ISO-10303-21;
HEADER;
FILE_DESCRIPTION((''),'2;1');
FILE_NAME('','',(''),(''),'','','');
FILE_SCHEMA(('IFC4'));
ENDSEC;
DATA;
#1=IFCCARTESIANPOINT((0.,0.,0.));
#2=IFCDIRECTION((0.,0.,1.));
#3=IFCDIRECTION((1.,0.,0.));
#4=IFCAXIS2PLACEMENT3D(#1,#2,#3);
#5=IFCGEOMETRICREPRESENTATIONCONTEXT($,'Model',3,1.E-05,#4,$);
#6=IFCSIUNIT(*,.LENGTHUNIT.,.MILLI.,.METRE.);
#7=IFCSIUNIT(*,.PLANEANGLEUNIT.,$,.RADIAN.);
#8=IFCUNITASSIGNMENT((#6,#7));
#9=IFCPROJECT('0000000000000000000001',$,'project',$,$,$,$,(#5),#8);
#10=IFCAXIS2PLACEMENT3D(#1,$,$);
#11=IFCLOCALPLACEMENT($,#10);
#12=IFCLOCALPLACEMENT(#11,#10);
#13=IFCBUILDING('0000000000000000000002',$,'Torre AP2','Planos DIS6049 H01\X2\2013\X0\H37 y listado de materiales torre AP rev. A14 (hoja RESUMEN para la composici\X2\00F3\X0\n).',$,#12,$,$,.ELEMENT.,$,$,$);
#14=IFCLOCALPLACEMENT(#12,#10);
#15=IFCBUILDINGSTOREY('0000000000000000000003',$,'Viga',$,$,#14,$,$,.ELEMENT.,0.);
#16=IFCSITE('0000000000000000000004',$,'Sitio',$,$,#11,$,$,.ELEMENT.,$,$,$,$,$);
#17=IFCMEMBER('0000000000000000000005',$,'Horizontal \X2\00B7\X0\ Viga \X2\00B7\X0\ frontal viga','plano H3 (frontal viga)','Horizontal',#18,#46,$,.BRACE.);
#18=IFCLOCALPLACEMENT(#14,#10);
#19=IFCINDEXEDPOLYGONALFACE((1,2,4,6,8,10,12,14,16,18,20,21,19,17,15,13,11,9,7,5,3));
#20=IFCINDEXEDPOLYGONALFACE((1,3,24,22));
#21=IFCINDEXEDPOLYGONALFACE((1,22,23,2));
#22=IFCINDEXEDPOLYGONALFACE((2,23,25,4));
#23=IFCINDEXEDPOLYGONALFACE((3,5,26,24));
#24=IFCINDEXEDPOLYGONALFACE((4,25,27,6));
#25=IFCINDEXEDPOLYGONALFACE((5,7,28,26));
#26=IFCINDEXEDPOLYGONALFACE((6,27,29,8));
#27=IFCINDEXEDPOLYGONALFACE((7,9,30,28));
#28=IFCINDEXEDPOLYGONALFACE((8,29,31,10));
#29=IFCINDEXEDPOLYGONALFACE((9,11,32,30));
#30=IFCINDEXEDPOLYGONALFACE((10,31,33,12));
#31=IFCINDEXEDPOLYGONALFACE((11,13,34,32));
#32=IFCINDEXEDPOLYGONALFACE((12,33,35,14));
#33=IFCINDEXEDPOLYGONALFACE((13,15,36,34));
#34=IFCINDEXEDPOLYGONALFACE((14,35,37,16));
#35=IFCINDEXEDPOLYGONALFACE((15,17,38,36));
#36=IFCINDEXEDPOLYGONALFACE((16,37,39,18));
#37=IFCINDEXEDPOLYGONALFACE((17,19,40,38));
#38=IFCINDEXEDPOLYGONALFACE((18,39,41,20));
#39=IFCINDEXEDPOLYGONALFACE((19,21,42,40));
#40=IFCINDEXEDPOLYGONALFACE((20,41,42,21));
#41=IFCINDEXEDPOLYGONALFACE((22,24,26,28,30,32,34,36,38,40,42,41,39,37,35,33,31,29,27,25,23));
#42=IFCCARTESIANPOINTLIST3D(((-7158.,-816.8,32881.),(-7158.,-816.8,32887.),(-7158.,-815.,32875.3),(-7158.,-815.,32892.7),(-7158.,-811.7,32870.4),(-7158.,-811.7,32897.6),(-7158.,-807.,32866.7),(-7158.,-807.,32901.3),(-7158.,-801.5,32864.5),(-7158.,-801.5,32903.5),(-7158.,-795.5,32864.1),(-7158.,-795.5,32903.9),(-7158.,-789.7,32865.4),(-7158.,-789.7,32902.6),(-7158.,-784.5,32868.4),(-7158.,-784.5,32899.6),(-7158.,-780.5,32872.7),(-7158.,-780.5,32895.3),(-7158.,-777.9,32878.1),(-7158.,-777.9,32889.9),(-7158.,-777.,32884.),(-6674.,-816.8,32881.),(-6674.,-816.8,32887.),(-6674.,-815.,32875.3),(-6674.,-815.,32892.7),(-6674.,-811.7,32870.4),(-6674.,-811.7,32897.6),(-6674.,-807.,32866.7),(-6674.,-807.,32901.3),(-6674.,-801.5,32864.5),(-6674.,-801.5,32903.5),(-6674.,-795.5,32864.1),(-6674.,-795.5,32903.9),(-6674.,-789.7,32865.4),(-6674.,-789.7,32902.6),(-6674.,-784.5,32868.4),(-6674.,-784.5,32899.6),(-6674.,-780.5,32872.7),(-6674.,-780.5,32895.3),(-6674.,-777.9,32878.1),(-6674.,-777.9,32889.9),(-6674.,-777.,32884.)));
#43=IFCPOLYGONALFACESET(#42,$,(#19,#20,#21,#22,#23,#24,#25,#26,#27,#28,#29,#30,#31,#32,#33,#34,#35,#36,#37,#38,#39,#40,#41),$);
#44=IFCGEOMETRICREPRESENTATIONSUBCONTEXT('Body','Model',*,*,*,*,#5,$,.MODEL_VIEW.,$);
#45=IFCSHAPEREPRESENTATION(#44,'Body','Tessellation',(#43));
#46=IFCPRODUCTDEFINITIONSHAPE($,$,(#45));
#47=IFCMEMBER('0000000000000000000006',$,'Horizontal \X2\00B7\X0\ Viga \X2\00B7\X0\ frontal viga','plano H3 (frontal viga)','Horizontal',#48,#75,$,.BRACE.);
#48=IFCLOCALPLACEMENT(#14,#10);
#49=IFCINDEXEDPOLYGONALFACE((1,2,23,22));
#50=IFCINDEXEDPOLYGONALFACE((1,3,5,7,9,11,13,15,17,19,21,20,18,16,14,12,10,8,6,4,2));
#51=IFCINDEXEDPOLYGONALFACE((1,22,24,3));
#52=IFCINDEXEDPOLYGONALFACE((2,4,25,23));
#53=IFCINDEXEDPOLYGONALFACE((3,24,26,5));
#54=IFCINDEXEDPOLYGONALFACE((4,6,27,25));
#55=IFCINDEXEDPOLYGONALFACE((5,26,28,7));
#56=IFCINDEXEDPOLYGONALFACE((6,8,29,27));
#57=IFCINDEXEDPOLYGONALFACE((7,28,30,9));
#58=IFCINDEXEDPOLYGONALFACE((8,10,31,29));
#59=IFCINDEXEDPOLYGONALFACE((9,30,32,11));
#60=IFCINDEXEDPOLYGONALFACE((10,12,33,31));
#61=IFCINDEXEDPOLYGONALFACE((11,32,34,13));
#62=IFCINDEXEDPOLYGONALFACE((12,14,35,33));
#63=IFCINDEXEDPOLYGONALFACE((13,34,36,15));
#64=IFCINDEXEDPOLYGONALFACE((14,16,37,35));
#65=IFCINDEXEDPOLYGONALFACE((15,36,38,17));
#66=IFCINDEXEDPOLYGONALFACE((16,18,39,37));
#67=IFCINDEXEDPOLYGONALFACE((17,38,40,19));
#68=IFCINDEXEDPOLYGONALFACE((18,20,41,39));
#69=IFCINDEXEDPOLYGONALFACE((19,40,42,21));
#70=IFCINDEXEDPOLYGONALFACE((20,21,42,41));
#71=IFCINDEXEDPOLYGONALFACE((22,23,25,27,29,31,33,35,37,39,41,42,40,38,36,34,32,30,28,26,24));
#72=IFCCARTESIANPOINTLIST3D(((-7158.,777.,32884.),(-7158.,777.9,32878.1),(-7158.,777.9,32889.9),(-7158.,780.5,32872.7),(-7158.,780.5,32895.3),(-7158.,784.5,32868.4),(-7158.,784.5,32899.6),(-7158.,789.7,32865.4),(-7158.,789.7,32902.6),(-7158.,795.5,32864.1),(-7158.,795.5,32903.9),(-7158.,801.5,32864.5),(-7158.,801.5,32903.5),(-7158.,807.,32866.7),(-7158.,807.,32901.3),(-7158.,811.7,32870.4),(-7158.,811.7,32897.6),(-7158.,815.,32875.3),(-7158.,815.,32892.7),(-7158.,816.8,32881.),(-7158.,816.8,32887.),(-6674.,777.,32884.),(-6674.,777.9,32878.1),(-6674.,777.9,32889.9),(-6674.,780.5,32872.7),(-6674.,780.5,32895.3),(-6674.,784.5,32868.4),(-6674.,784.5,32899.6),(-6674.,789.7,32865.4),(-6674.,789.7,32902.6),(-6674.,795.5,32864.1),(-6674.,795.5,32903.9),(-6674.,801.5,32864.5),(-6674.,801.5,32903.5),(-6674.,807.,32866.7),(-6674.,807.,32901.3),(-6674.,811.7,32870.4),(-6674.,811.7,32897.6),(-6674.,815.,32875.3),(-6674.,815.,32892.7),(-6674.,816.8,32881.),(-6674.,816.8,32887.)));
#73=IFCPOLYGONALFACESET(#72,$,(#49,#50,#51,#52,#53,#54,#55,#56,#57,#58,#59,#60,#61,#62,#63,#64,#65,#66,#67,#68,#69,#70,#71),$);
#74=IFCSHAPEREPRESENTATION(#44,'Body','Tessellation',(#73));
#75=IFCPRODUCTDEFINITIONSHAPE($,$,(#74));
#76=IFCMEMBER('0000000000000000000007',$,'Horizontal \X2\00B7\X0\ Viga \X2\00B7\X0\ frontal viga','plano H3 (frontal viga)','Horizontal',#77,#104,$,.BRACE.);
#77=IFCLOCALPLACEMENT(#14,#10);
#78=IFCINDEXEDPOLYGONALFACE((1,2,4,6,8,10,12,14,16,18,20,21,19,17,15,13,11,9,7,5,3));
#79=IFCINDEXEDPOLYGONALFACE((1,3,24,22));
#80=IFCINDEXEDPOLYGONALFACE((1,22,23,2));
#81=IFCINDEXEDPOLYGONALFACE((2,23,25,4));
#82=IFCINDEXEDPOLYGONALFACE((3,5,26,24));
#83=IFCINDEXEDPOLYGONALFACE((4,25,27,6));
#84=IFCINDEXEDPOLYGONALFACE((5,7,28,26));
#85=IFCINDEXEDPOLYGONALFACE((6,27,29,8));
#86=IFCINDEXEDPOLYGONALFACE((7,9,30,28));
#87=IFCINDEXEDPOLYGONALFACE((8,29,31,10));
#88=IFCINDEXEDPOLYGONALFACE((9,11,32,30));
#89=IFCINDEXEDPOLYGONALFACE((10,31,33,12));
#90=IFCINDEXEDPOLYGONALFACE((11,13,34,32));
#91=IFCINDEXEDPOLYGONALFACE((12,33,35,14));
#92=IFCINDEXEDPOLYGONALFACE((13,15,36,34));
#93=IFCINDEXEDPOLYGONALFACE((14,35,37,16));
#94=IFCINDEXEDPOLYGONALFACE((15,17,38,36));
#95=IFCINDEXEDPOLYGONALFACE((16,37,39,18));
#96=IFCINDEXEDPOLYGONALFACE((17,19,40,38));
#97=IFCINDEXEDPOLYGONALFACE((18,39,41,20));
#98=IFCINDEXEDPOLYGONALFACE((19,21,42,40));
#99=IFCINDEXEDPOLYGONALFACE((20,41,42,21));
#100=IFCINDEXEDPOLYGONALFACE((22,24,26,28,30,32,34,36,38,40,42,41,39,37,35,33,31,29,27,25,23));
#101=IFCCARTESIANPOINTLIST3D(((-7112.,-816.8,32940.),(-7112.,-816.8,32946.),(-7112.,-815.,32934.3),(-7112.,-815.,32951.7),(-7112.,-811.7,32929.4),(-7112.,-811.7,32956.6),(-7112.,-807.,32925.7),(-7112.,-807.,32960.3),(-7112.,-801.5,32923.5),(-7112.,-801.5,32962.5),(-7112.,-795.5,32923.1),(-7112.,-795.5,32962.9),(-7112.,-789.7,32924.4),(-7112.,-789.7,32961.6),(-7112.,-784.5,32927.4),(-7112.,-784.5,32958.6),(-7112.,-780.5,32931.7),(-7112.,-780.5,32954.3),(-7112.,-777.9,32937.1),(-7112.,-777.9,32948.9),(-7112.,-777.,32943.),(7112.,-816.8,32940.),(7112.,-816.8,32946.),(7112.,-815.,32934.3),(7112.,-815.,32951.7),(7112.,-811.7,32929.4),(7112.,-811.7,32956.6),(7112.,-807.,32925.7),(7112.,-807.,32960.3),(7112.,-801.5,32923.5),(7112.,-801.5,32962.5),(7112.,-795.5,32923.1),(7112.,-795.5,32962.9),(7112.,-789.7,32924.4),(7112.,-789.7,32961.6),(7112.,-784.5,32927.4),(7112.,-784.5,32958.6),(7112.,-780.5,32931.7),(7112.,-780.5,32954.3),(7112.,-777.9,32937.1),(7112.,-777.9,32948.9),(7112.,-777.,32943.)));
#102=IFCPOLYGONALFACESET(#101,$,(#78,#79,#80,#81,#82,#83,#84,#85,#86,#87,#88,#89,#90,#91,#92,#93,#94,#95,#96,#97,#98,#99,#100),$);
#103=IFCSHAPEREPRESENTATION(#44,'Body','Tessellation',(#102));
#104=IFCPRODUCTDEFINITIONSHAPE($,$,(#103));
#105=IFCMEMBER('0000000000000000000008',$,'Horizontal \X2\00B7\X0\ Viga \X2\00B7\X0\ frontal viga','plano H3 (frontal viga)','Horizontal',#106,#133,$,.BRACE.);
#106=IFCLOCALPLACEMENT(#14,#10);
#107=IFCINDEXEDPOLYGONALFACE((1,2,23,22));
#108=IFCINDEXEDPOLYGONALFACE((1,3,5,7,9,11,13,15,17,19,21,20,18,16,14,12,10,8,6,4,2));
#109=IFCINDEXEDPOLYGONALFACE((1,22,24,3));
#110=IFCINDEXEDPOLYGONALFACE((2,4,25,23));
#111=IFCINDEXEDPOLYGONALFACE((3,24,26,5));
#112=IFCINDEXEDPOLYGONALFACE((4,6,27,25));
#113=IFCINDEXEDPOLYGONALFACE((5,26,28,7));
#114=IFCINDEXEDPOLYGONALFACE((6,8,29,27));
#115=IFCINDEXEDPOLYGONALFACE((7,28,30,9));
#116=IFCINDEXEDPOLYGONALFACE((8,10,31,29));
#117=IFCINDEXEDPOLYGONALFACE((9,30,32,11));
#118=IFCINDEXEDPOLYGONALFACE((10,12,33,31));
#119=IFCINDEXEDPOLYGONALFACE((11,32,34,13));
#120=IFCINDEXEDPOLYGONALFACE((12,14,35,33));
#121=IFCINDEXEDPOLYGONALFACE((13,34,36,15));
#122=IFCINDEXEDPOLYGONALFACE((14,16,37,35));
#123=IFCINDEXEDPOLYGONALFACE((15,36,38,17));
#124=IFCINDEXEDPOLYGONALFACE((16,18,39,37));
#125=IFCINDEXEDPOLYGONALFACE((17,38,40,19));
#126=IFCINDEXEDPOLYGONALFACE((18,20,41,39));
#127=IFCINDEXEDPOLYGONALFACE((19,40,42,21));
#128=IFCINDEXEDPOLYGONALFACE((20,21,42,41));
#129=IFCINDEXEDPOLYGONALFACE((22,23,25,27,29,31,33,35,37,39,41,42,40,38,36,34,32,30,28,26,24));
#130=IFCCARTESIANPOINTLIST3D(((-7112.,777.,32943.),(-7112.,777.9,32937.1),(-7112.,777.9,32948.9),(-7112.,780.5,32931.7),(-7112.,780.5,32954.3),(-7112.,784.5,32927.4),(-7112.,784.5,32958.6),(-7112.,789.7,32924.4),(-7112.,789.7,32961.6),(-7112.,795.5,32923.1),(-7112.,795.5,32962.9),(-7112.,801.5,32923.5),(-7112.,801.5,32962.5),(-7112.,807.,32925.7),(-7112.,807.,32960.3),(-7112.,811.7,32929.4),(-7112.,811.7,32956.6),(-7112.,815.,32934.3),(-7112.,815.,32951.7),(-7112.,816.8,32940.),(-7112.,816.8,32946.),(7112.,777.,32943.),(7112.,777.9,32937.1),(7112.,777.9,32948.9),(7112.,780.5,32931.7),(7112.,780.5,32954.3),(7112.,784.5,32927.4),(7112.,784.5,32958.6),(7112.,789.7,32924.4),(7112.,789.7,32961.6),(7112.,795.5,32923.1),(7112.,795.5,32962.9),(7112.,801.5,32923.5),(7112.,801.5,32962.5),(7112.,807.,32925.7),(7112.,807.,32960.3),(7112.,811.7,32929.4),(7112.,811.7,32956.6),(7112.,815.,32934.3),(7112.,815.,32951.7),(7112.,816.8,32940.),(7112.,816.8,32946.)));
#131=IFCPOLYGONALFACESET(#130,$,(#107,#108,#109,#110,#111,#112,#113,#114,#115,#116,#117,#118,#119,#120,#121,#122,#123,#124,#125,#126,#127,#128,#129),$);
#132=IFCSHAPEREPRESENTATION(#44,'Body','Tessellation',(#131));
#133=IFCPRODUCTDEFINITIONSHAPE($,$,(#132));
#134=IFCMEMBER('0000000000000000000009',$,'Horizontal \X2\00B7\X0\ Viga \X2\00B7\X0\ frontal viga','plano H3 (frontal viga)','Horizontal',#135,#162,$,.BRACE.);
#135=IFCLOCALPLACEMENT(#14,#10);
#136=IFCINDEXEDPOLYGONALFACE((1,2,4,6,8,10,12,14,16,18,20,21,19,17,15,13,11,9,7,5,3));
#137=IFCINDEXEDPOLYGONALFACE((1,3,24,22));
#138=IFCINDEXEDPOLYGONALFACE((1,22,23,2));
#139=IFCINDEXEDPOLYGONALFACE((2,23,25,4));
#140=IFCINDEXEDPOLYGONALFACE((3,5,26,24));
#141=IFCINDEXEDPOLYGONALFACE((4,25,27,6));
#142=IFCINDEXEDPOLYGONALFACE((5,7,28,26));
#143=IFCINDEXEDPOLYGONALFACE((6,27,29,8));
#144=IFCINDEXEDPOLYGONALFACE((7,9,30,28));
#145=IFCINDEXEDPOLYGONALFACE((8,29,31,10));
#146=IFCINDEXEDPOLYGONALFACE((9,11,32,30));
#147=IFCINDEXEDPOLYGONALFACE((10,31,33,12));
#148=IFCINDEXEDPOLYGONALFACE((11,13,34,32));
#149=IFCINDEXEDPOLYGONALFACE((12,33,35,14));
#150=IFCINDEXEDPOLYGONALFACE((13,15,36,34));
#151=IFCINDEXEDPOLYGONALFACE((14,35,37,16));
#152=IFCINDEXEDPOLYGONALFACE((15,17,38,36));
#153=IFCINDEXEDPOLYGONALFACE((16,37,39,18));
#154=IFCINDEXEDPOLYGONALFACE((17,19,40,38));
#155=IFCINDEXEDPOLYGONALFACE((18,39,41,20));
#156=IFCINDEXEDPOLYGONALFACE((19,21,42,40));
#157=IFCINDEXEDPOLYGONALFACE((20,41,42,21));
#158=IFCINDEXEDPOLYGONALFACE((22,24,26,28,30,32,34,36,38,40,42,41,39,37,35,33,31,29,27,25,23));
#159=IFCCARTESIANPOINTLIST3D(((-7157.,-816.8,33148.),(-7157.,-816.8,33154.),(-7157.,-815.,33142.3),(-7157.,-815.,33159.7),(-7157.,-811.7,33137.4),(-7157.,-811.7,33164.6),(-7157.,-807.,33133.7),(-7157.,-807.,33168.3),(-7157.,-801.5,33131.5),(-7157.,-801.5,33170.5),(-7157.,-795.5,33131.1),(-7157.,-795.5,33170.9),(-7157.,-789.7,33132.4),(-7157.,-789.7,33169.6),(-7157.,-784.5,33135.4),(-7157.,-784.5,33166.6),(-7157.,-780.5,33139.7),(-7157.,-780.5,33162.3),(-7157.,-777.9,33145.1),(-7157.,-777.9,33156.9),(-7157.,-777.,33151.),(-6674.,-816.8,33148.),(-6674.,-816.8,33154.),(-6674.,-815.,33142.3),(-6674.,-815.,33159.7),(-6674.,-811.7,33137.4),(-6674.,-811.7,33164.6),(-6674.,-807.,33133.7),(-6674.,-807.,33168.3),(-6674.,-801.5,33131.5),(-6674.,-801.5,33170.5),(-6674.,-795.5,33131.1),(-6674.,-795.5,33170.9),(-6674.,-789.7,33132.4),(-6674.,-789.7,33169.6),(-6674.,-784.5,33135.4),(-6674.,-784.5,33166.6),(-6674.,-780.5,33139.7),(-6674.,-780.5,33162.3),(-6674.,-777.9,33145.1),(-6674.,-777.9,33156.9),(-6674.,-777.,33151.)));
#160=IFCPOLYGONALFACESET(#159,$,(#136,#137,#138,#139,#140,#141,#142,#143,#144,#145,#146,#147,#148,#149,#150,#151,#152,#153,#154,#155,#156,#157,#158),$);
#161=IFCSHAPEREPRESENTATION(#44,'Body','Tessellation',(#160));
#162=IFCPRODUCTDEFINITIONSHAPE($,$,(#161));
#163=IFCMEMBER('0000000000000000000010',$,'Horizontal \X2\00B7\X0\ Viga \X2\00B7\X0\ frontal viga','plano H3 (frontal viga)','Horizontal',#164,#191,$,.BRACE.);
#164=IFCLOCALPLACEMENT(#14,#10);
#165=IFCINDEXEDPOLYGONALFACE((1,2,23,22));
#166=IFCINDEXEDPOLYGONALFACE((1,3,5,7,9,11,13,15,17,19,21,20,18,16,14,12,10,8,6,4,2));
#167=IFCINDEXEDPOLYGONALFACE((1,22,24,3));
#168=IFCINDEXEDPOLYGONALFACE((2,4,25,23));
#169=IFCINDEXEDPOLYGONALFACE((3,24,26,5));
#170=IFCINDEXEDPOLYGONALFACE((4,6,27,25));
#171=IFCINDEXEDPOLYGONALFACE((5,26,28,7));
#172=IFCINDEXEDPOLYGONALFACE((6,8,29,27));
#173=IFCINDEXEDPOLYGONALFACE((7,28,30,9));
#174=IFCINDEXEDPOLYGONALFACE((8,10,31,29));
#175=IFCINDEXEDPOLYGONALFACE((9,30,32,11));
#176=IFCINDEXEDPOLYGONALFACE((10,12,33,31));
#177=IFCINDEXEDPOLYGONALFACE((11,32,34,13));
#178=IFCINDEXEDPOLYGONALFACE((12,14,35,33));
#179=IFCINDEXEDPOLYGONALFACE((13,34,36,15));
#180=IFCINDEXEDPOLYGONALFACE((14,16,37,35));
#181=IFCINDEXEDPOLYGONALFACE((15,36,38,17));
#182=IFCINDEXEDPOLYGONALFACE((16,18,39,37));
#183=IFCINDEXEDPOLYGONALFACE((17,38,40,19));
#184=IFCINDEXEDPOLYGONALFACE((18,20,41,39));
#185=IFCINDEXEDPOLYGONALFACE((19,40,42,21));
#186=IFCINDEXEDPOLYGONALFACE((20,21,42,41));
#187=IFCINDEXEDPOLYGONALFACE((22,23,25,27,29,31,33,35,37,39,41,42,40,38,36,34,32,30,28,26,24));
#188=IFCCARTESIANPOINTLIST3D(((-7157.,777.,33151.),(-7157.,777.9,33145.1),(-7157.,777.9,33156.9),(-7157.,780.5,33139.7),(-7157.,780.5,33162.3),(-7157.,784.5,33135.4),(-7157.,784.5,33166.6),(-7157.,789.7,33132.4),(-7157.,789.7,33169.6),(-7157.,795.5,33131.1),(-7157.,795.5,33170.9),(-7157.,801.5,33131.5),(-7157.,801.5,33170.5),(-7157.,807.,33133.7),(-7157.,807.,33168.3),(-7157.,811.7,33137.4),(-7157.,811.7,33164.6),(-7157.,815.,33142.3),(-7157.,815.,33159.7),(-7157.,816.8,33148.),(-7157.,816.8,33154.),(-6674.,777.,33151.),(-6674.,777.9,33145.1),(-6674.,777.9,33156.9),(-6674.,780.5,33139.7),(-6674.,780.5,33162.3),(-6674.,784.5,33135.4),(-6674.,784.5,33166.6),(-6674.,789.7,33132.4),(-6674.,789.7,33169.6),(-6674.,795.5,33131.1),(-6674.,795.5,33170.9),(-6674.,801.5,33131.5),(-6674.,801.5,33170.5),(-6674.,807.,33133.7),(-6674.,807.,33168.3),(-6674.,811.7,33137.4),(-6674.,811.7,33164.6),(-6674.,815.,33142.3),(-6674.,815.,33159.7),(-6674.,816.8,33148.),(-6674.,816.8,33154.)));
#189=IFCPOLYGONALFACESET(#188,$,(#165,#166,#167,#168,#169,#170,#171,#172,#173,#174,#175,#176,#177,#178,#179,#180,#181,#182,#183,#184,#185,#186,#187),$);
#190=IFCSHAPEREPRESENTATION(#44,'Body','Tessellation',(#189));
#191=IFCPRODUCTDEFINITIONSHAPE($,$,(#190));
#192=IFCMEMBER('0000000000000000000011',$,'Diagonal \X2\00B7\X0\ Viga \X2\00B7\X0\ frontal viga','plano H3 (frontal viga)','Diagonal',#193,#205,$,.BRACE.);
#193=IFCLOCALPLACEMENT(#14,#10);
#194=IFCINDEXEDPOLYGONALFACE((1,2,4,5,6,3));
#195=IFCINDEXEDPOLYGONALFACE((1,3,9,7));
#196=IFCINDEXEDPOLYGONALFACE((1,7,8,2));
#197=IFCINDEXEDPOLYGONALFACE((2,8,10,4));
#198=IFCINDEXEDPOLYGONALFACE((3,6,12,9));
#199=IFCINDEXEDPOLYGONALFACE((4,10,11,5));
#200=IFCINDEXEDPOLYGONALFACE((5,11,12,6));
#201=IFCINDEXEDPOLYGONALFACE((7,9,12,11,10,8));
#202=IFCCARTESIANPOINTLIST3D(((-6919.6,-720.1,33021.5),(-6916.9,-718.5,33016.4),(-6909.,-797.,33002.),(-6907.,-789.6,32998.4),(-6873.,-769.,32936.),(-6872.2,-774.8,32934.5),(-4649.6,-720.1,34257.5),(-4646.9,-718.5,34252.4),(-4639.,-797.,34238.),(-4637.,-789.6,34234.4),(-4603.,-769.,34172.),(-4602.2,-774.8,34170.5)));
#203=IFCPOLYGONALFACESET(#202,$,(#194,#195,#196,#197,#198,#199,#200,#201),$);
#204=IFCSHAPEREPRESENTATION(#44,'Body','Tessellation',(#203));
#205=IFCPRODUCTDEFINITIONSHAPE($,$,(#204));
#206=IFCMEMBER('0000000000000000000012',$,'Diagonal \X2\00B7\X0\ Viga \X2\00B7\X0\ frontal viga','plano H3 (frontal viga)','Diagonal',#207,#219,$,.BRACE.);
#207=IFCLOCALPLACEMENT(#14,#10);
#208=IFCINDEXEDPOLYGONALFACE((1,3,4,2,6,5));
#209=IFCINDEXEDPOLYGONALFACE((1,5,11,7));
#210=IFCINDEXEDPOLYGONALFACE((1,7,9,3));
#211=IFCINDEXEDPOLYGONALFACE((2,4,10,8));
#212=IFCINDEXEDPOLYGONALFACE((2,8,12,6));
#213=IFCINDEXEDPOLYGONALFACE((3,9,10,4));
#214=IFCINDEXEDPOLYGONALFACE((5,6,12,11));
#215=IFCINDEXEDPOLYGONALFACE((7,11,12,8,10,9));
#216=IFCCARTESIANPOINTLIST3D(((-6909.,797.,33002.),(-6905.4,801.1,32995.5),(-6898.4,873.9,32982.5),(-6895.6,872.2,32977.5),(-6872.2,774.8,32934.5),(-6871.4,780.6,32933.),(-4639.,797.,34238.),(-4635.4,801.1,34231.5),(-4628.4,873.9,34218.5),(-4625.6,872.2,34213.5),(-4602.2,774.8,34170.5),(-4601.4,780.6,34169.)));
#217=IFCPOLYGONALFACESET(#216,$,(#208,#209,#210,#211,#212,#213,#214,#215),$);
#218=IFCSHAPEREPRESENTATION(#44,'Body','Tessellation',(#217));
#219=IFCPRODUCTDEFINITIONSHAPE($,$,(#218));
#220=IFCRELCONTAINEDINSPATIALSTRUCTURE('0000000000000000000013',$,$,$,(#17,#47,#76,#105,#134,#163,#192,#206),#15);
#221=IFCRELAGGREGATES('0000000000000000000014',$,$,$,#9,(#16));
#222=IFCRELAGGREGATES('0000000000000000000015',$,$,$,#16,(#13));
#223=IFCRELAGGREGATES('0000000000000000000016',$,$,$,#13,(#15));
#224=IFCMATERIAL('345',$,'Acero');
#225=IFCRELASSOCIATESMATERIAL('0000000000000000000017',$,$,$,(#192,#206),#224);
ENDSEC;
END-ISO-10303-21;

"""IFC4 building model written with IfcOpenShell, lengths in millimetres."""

from ifc_helpers import new_model, si_unit, frame, frame_2d, origin, origin_with_axes, place, context, subcontext, project, spatial, circle, l_section, extrude, material, element, save


model = new_model("IFC4")

# Units and contexts
model_context = context("Model", 3, precision=1e-05, world=origin_with_axes())
body_context = subcontext(model_context, "Body", "Model", "MODEL_VIEW")
ifc_project = project(units=[si_unit("LENGTHUNIT", "METRE", prefix="MILLI"), si_unit("PLANEANGLEUNIT", "RADIAN")], contexts=[model_context])

# Site, building, storey
site_placement = place(None, origin())
site = spatial("IfcSite", under=ifc_project, at=site_placement, Name="Sitio", CompositionType="ELEMENT")
building_placement = place(site_placement, origin())
building = spatial("IfcBuilding", under=site, at=building_placement, Name="Torre AP2", Description="Planos DIS6049 H01–H37 y listado de materiales torre AP rev. A14 (hoja RESUMEN para la composición).", CompositionType="ELEMENT")
storey_placement = place(building_placement, origin())
storey = spatial("IfcBuildingStorey", under=building, at=storey_placement, Name="Viga", CompositionType="ELEMENT", Elevation=0.0)

# Members
for number, where, z_axis, x_axis, name in (
    (1, (-7158.0, -797.0, 32884.0), (1.0, 0.0, 0.0), (0.0, 1.0, 0.0), "Horizontal · Viga · frontal viga"),
    (2, (-7158.0, 797.0, 32884.0), (1.0, 0.0, 0.0), (0.0, -1.0, 0.0), "Horizontal · Viga · frontal viga"),
):
    element("IfcMember", number, at=place(storey_placement, frame(where, z_axis=z_axis, x_axis=x_axis)), inside=storey, Name=name, Description="plano H3 (frontal viga)", ObjectType="Horizontal", PredefinedType="BRACE", context=body_context, shape_type="SweptSolid", body=[
        extrude(circle(Radius=20.0), None, (0.0, 0.0, 1.0), 484.0),
    ])
for number, where, z_axis, x_axis, name in (
    (3, (-7112.0, -797.0, 32943.0), (1.0, 0.0, 0.0), (0.0, 1.0, 0.0), "Horizontal · Viga · frontal viga"),
    (4, (-7112.0, 797.0, 32943.0), (1.0, 0.0, 0.0), (0.0, -1.0, 0.0), "Horizontal · Viga · frontal viga"),
):
    element("IfcMember", number, at=place(storey_placement, frame(where, z_axis=z_axis, x_axis=x_axis)), inside=storey, Name=name, Description="plano H3 (frontal viga)", ObjectType="Horizontal", PredefinedType="BRACE", context=body_context, shape_type="SweptSolid", body=[
        extrude(circle(Radius=20.0), None, (0.0, 0.0, 1.0), 14224.0),
    ])
for number, where, z_axis, x_axis, name in (
    (5, (-7157.0, -797.0, 33151.0), (1.0, 0.0, 0.0), (0.0, 1.0, 0.0), "Horizontal · Viga · frontal viga"),
    (6, (-7157.0, 797.0, 33151.0), (1.0, 0.0, 0.0), (0.0, -1.0, 0.0), "Horizontal · Viga · frontal viga"),
):
    element("IfcMember", number, at=place(storey_placement, frame(where, z_axis=z_axis, x_axis=x_axis)), inside=storey, Name=name, Description="plano H3 (frontal viga)", ObjectType="Horizontal", PredefinedType="BRACE", context=body_context, shape_type="SweptSolid", body=[
        extrude(circle(Radius=20.0), None, (0.0, 0.0, 1.0), 483.0),
    ])
ifc_material_1 = material(Name="345", Category="Acero")
for number, where, z_axis, x_axis, name in (
    (7, (-6909.0, -797.0, 33002.0), (0.87825, 0.0, 0.478201), (0.459444, 0.277327, -0.843801), "Diagonal · Viga · frontal viga"),
    (8, (-6909.0, 797.0, 33002.0), (0.87825, 0.0, 0.478201), (0.459444, -0.277327, -0.843801), "Diagonal · Viga · frontal viga"),
):
    element("IfcMember", number, at=place(storey_placement, frame(where, z_axis=z_axis, x_axis=x_axis)), inside=storey, material=ifc_material_1, Name=name, Description="plano H3 (frontal viga)", ObjectType="Diagonal", PredefinedType="BRACE", context=body_context, shape_type="SweptSolid", body=[
        extrude(l_section(Depth=80.0, Width=80.0, Thickness=6.0, at=frame_2d((40.0, 40.0))), None, (0.0, 0.0, 1.0), 2584.7),
    ])

save(model, "model.ifc")
